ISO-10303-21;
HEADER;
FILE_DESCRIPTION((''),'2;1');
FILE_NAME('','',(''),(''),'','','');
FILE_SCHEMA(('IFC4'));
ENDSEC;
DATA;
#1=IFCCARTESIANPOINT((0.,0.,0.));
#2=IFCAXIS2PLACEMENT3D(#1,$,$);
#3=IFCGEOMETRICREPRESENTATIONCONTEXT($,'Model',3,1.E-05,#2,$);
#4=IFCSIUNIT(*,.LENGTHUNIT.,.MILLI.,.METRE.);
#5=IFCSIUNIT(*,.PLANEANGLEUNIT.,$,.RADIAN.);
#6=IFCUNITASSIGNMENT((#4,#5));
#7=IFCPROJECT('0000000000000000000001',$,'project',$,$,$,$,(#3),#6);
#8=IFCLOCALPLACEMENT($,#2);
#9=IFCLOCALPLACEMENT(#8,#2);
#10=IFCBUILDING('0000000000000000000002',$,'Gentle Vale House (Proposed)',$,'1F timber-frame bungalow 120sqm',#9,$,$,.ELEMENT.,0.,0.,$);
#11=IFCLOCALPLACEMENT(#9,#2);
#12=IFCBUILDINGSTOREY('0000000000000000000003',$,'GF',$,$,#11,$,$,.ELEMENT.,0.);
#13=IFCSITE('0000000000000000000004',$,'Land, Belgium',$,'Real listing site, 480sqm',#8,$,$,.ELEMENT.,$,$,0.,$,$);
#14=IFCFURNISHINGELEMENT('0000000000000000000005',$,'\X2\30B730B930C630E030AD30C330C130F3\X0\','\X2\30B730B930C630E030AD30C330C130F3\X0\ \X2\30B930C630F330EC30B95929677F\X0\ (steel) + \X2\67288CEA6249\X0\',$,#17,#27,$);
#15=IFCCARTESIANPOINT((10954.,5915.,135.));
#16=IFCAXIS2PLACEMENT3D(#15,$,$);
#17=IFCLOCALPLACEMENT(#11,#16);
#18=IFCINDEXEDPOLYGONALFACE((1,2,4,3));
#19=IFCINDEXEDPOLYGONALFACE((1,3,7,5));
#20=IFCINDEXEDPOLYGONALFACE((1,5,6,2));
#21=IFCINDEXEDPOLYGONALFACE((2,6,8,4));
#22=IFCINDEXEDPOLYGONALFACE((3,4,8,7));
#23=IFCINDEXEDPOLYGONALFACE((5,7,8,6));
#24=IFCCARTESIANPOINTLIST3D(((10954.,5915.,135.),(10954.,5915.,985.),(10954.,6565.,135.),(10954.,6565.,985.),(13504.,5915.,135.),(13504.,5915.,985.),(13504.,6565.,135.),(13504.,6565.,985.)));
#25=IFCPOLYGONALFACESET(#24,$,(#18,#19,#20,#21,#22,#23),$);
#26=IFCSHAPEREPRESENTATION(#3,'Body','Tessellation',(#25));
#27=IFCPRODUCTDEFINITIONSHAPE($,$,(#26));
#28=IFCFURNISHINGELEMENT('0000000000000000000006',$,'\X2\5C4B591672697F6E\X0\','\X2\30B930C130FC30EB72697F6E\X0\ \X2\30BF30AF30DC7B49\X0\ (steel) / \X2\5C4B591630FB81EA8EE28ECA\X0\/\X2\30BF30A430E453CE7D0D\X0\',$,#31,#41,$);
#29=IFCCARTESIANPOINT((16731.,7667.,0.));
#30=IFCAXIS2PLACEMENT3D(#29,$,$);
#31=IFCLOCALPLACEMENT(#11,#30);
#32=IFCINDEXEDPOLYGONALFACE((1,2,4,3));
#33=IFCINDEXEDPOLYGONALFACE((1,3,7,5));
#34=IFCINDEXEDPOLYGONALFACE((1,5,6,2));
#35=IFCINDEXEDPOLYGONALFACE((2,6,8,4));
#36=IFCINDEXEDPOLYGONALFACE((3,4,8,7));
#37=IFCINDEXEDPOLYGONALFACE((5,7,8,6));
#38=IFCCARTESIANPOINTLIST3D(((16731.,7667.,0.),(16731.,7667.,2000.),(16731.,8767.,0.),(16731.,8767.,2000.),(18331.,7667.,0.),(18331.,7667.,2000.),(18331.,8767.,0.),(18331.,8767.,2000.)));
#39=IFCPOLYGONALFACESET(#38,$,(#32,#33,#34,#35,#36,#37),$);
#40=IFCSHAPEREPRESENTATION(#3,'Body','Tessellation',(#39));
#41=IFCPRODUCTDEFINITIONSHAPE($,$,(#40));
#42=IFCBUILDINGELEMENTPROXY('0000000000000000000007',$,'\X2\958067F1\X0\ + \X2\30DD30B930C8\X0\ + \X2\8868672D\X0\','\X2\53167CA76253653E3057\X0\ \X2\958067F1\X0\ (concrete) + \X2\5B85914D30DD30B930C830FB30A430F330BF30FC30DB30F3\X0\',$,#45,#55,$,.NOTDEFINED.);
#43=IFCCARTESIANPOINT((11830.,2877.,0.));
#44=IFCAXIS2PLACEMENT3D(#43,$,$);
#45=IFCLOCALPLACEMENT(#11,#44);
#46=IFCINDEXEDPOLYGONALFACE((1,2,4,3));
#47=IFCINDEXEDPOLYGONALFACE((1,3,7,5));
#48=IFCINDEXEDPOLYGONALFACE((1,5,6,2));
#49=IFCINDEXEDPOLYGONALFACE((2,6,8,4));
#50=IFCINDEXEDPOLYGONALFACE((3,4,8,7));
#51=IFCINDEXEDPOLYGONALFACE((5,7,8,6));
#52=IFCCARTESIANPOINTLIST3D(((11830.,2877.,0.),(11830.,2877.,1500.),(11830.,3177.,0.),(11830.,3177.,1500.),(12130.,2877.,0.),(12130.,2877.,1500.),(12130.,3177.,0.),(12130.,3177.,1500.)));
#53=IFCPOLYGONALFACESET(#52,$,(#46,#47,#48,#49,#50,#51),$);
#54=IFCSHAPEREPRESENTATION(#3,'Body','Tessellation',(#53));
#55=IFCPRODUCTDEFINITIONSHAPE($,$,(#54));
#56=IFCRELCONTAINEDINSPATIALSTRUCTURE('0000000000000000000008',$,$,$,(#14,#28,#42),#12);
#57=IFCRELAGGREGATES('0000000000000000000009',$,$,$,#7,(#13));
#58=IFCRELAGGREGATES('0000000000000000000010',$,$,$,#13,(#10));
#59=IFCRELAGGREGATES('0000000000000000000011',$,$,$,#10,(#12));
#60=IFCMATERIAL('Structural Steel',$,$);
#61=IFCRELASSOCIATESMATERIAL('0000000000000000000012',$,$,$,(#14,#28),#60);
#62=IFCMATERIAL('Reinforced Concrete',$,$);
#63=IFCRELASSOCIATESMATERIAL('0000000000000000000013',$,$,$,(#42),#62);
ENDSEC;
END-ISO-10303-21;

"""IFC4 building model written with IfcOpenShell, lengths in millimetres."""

from ifc_helpers import new_model, si_unit, frame, frame_2d, origin, place, context, project, spatial, rectangle, extrude, material, element, save


model = new_model("IFC4")

# Units and contexts
model_context = context("Model", 3, precision=1e-05, world=origin())
ifc_project = project(units=[si_unit("LENGTHUNIT", "METRE", prefix="MILLI"), si_unit("PLANEANGLEUNIT", "RADIAN")], contexts=[model_context])

# Site, building, storey
site_placement = place(None, origin())
site = spatial("IfcSite", under=ifc_project, at=site_placement, Name="Land, Belgium", ObjectType="Real listing site, 480sqm", CompositionType="ELEMENT", RefElevation=0.0)
building_placement = place(site_placement, origin())
building = spatial("IfcBuilding", under=site, at=building_placement, Name="Gentle Vale House (Proposed)", ObjectType="1F timber-frame bungalow 120sqm", CompositionType="ELEMENT", ElevationOfRefHeight=0.0, ElevationOfTerrain=0.0)
storey_placement = place(building_placement, origin())
storey = spatial("IfcBuildingStorey", under=building, at=storey_placement, Name="GF", CompositionType="ELEMENT", Elevation=0.0)

# Shared definitions
ifc_material_1 = material(Name="Reinforced Concrete")

# Shared definitions
ifc_material_2 = material(Name="Structural Steel")

# Furnishing elements
furnishing_1_placement = place(storey_placement, frame((10954.0, 5915.0, 135.0)))
element("IfcFurnishingElement", 1, at=furnishing_1_placement, inside=storey, material=ifc_material_2, Name="システムキッチン", Description="システムキッチン ステンレス天板 (steel) + 木質扉", context=model_context, shape_type="SweptSolid", body=[
    extrude(rectangle(XDim=2550.0, YDim=650.0, at=frame_2d((1275.0, 325.0))), frame((10954.0, 5915.0, 135.0)), (0.0, 0.0, 1.0), 850.0),
])
furnishing_2_placement = place(storey_placement, frame((16731.0, 7667.0, 0.0)))
element("IfcFurnishingElement", 2, at=furnishing_2_placement, inside=storey, material=ifc_material_2, Name="屋外物置", Description="スチール物置 タクボ等 (steel) / 屋外・自転車/タイヤ収納", context=model_context, shape_type="SweptSolid", body=[
    extrude(rectangle(XDim=1600.0, YDim=1100.0, at=frame_2d((800.0, 550.0))), frame((16731.0, 7667.0, 0.0)), (0.0, 0.0, 1.0), 2000.0),
])

# Building element proxy
proxy_placement = place(storey_placement, frame((11830.0, 2877.0, 0.0)))
element("IfcBuildingElementProxy", 3, at=proxy_placement, inside=storey, material=ifc_material_1, Name="門柱 + ポスト + 表札", Description="化粧打放し 門柱 (concrete) + 宅配ポスト・インターホン", PredefinedType="NOTDEFINED", context=model_context, shape_type="SweptSolid", body=[
    extrude(rectangle(XDim=300.0, YDim=300.0, at=frame_2d((150.0, 150.0))), frame((11830.0, 2877.0, 0.0)), (0.0, 0.0, 1.0), 1500.0),
])

save(model, "model.ifc")
